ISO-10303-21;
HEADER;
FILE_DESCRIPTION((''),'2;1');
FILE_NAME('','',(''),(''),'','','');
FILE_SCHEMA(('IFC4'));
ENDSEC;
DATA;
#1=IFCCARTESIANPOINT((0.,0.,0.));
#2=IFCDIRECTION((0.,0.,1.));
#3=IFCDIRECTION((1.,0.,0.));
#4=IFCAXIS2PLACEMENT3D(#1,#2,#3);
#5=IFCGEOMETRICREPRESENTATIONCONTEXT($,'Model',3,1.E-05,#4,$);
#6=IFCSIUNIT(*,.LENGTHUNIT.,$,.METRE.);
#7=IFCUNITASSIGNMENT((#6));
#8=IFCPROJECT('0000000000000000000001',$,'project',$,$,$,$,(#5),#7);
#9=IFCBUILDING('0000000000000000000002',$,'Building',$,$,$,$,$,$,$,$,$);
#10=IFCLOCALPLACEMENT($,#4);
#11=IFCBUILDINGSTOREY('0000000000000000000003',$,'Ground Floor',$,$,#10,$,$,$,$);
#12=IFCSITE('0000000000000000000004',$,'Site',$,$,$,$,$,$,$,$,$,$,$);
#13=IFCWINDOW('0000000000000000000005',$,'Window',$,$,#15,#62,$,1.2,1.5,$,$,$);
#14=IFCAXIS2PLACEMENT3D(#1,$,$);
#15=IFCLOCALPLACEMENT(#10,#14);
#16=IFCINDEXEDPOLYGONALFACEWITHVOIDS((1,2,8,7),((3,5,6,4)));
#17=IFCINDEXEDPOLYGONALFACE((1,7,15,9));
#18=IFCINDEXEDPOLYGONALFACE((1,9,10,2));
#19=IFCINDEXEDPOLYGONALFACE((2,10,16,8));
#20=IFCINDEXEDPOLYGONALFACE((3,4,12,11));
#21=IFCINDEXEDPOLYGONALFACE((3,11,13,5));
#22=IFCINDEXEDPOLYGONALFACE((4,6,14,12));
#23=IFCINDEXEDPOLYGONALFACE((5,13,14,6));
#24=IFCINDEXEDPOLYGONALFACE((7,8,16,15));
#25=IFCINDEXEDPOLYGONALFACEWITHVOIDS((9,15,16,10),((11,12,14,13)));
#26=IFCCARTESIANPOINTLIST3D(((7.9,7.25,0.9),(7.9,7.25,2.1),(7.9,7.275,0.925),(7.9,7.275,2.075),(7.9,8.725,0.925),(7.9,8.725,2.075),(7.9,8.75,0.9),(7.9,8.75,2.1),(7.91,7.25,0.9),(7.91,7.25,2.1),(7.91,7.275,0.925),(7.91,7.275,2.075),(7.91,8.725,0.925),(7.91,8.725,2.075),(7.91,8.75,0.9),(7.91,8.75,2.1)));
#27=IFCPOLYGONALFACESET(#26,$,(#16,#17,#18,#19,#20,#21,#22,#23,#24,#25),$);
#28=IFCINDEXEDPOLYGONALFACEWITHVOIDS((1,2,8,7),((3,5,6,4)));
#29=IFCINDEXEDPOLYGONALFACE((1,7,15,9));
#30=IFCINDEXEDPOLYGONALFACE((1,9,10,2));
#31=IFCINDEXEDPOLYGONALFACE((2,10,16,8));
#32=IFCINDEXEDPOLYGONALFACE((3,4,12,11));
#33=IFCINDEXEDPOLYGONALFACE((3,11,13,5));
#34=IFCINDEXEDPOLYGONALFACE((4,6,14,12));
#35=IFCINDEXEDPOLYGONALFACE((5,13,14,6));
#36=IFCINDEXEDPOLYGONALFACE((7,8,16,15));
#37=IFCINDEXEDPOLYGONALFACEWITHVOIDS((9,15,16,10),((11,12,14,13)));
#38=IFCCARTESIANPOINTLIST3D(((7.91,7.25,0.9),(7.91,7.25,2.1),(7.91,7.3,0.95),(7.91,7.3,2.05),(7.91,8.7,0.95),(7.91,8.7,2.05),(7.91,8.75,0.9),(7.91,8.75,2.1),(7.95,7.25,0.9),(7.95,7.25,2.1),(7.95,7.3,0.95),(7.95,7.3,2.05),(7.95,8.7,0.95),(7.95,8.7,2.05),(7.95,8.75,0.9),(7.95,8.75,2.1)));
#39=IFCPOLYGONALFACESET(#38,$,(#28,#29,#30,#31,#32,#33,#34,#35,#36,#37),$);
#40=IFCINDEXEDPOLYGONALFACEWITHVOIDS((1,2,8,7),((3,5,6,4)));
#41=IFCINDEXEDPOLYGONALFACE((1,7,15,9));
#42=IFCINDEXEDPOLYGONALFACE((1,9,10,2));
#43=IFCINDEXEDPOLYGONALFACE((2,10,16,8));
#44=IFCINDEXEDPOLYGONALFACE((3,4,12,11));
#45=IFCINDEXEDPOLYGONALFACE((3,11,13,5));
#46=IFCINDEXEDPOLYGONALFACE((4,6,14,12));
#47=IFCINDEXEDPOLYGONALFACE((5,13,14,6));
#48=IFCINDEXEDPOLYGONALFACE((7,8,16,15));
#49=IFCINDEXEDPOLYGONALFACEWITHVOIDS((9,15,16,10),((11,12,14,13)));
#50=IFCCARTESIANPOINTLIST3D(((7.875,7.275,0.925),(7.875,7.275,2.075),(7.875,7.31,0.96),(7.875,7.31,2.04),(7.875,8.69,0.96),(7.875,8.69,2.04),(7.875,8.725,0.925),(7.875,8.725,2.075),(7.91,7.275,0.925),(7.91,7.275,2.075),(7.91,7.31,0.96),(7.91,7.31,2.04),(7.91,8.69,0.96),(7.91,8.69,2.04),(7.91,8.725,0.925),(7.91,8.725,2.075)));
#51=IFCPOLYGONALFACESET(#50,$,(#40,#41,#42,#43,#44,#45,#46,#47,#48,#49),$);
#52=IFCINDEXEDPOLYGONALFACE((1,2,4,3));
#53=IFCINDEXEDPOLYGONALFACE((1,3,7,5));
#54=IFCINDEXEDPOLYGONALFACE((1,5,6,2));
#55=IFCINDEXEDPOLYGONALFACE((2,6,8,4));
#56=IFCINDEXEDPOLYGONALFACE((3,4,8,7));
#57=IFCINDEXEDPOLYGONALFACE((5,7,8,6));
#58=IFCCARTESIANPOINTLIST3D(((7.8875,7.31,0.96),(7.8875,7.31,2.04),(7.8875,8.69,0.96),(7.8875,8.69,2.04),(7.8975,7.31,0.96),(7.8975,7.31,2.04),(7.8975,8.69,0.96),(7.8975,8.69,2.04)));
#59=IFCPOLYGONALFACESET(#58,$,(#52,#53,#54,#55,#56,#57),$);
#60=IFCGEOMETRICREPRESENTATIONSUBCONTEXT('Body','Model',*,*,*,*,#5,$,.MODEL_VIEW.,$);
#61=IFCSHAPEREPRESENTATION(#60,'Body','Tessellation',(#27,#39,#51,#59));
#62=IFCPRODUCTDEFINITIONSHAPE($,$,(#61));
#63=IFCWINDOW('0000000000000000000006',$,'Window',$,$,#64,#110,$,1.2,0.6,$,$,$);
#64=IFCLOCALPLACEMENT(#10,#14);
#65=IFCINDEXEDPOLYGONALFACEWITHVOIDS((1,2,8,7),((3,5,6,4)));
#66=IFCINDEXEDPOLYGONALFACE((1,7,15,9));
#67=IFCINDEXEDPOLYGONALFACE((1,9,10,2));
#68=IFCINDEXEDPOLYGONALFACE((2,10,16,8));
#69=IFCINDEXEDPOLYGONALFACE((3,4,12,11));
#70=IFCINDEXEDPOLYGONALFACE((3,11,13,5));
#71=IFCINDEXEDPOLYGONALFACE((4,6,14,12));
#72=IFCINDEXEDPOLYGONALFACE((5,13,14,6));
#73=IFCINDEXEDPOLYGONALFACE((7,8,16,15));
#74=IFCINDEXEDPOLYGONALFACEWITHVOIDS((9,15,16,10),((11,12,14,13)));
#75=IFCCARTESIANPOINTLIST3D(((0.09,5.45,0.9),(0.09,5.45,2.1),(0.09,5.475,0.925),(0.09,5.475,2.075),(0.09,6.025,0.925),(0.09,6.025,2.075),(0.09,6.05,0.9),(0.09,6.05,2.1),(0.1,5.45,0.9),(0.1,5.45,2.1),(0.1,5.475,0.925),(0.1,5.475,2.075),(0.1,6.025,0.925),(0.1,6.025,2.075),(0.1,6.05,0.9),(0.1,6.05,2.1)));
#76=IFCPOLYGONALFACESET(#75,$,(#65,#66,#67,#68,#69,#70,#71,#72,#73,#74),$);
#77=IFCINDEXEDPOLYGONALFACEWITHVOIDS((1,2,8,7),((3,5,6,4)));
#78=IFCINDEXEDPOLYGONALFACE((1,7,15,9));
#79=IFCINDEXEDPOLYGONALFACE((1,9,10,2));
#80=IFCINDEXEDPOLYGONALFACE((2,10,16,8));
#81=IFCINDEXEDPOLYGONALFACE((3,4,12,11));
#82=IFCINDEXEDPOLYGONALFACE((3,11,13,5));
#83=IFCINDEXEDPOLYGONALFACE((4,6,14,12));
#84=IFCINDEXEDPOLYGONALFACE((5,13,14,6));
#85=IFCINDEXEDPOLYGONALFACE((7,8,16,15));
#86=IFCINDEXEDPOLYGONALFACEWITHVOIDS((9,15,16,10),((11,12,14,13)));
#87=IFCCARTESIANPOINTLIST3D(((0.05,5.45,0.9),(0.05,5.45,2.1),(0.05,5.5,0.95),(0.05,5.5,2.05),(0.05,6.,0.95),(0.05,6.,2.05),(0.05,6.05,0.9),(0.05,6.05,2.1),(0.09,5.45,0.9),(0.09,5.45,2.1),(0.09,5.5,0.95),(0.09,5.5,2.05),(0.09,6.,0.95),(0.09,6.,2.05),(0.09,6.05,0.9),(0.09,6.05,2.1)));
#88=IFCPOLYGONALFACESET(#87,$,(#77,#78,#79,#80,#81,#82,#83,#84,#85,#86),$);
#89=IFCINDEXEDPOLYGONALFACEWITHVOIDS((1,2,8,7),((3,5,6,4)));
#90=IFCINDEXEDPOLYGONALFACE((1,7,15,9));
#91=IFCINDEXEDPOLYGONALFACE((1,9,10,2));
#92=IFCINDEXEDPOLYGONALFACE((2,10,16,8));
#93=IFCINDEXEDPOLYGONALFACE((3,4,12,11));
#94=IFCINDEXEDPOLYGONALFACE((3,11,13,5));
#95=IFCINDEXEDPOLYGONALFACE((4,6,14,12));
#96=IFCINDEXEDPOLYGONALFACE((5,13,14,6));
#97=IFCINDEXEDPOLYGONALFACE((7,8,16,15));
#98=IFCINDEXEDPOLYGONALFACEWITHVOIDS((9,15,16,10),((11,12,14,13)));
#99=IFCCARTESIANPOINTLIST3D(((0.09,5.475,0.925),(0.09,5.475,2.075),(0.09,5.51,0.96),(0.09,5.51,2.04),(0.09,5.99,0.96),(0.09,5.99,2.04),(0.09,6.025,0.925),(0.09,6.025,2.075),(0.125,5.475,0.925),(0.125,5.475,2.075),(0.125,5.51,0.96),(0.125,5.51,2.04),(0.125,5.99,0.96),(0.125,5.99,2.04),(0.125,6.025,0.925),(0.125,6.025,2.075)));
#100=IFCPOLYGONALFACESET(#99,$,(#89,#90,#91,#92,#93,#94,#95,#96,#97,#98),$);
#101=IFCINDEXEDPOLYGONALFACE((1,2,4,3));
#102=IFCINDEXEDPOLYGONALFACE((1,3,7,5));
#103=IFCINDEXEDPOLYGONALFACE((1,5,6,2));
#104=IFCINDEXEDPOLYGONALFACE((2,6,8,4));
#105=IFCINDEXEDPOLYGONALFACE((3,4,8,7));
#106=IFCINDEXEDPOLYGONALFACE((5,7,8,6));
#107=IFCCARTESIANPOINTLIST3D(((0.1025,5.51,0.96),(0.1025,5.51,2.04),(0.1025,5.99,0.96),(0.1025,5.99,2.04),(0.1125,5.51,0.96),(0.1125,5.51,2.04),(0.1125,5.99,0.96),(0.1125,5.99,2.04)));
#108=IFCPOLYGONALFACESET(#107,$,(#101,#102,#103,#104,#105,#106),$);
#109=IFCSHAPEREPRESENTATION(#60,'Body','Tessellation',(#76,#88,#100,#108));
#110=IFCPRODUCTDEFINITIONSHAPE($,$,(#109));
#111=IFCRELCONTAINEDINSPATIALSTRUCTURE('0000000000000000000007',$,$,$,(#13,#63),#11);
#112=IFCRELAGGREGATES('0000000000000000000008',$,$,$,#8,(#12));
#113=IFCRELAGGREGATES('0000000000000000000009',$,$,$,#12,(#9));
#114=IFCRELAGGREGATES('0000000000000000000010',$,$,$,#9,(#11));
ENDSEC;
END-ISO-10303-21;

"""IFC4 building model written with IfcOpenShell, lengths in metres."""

from ifc_helpers import new_model, si_unit, frame, origin_with_axes, place, context, subcontext, project, spatial, line, indexed_curve, outline, extrude, element, save


model = new_model("IFC4")

# Units and contexts
model_context = context("Model", 3, precision=1e-05, world=origin_with_axes())
body_context = subcontext(model_context, "Body", "Model", "MODEL_VIEW")
ifc_project = project(units=[si_unit("LENGTHUNIT", "METRE")], contexts=[model_context])

# Site, building, storey
site = spatial("IfcSite", under=ifc_project, Name="Site")
building = spatial("IfcBuilding", under=site, Name="Building")
storey_placement = place(None, origin_with_axes())
storey = spatial("IfcBuildingStorey", under=building, at=storey_placement, Name="Ground Floor")

# Windows
for number, where, z_axis, x_axis, name in (
    (1, (8.0, 7.25, 0.9), (0.0, 0.0, 1.0), (0.0, 1.0, 0.0), "Window"),
):
    element("IfcWindow", number, at=place(storey_placement, frame(where, z_axis=z_axis, x_axis=x_axis)), inside=storey, Name=name, OverallHeight=1.2, OverallWidth=1.5, context=body_context, shape_type="SweptSolid", body=[
        extrude(outline(indexed_curve([(0.0, 0.0), (1.5, 0.0), (1.5, 1.2), (0.0, 1.2)], segments=[line(1, 2, 3, 4, 1)]), holes=[indexed_curve([(0.025, 0.025), (1.475, 0.025), (1.475, 1.175), (0.025, 1.175)], segments=[line(1, 2, 3, 4, 1)])]), frame((0.0, 0.09, 0.0), z_axis=(0.0, -1.0, 0.0), x_axis=(1.0, 0.0, 0.0)), (0.0, 0.0, -1.0), 0.01),
        extrude(outline(indexed_curve([(0.0, 0.0), (1.5, 0.0), (1.5, 1.2), (0.0, 1.2)], segments=[line(1, 2, 3, 4, 1)]), holes=[indexed_curve([(0.05, 0.05), (1.45, 0.05), (1.45, 1.15), (0.05, 1.15)], segments=[line(1, 2, 3, 4, 1)])]), frame((0.0, 0.05, 0.0), z_axis=(0.0, -1.0, 0.0), x_axis=(1.0, 0.0, 0.0)), (0.0, 0.0, -1.0), 0.04),
        extrude(outline(indexed_curve([(0.0, 0.0), (1.45, 0.0), (1.45, 1.15), (0.0, 1.15)], segments=[line(1, 2, 3, 4, 1)]), holes=[indexed_curve([(0.035, 0.035), (1.415, 0.035), (1.415, 1.115), (0.035, 1.115)], segments=[line(1, 2, 3, 4, 1)])]), frame((0.025, 0.09, 0.025), z_axis=(0.0, -1.0, 0.0), x_axis=(1.0, 0.0, 0.0)), (0.0, 0.0, -1.0), 0.035),
        extrude(outline(indexed_curve([(0.035, 0.035), (1.415, 0.035), (1.415, 1.115), (0.035, 1.115)], segments=[line(1, 2, 3, 4, 1)])), frame((0.025, 0.1025, 0.025), z_axis=(0.0, -1.0, 0.0), x_axis=(1.0, 0.0, 0.0)), (0.0, 0.0, -1.0), 0.01),
    ])
window_1_placement = place(storey_placement, frame((0.0, 6.05, 0.9), z_axis=(0.0, 0.0, 1.0), x_axis=(0.0, -1.0, 0.0)))
element("IfcWindow", 2, at=window_1_placement, inside=storey, Name="Window", OverallHeight=1.2, OverallWidth=0.6, context=body_context, shape_type="SweptSolid", body=[
    extrude(outline(indexed_curve([(0.0, 0.0), (0.6, 0.0), (0.6, 1.2), (0.0, 1.2)], segments=[line(1, 2, 3, 4, 1)]), holes=[indexed_curve([(0.025, 0.025), (0.575, 0.025), (0.575, 1.175), (0.025, 1.175)], segments=[line(1, 2, 3, 4, 1)])]), frame((0.0, 0.09, 0.0), z_axis=(0.0, -1.0, 0.0), x_axis=(1.0, 0.0, 0.0)), (0.0, 0.0, -1.0), 0.01),
    extrude(outline(indexed_curve([(0.0, 0.0), (0.6, 0.0), (0.6, 1.2), (0.0, 1.2)], segments=[line(1, 2, 3, 4, 1)]), holes=[indexed_curve([(0.05, 0.05), (0.55, 0.05), (0.55, 1.15), (0.05, 1.15)], segments=[line(1, 2, 3, 4, 1)])]), frame((0.0, 0.05, 0.0), z_axis=(0.0, -1.0, 0.0), x_axis=(1.0, 0.0, 0.0)), (0.0, 0.0, -1.0), 0.04),
    extrude(outline(indexed_curve([(0.0, 0.0), (0.55, 0.0), (0.55, 1.15), (0.0, 1.15)], segments=[line(1, 2, 3, 4, 1)]), holes=[indexed_curve([(0.035, 0.035), (0.515, 0.035), (0.515, 1.115), (0.035, 1.115)], segments=[line(1, 2, 3, 4, 1)])]), frame((0.025, 0.09, 0.025), z_axis=(0.0, -1.0, 0.0), x_axis=(1.0, 0.0, 0.0)), (0.0, 0.0, -1.0), 0.035),
    extrude(outline(indexed_curve([(0.035, 0.035), (0.515, 0.035), (0.515, 1.115), (0.035, 1.115)], segments=[line(1, 2, 3, 4, 1)])), frame((0.025, 0.1025, 0.025), z_axis=(0.0, -1.0, 0.0), x_axis=(1.0, 0.0, 0.0)), (0.0, 0.0, -1.0), 0.01),
])

save(model, "model.ifc")
